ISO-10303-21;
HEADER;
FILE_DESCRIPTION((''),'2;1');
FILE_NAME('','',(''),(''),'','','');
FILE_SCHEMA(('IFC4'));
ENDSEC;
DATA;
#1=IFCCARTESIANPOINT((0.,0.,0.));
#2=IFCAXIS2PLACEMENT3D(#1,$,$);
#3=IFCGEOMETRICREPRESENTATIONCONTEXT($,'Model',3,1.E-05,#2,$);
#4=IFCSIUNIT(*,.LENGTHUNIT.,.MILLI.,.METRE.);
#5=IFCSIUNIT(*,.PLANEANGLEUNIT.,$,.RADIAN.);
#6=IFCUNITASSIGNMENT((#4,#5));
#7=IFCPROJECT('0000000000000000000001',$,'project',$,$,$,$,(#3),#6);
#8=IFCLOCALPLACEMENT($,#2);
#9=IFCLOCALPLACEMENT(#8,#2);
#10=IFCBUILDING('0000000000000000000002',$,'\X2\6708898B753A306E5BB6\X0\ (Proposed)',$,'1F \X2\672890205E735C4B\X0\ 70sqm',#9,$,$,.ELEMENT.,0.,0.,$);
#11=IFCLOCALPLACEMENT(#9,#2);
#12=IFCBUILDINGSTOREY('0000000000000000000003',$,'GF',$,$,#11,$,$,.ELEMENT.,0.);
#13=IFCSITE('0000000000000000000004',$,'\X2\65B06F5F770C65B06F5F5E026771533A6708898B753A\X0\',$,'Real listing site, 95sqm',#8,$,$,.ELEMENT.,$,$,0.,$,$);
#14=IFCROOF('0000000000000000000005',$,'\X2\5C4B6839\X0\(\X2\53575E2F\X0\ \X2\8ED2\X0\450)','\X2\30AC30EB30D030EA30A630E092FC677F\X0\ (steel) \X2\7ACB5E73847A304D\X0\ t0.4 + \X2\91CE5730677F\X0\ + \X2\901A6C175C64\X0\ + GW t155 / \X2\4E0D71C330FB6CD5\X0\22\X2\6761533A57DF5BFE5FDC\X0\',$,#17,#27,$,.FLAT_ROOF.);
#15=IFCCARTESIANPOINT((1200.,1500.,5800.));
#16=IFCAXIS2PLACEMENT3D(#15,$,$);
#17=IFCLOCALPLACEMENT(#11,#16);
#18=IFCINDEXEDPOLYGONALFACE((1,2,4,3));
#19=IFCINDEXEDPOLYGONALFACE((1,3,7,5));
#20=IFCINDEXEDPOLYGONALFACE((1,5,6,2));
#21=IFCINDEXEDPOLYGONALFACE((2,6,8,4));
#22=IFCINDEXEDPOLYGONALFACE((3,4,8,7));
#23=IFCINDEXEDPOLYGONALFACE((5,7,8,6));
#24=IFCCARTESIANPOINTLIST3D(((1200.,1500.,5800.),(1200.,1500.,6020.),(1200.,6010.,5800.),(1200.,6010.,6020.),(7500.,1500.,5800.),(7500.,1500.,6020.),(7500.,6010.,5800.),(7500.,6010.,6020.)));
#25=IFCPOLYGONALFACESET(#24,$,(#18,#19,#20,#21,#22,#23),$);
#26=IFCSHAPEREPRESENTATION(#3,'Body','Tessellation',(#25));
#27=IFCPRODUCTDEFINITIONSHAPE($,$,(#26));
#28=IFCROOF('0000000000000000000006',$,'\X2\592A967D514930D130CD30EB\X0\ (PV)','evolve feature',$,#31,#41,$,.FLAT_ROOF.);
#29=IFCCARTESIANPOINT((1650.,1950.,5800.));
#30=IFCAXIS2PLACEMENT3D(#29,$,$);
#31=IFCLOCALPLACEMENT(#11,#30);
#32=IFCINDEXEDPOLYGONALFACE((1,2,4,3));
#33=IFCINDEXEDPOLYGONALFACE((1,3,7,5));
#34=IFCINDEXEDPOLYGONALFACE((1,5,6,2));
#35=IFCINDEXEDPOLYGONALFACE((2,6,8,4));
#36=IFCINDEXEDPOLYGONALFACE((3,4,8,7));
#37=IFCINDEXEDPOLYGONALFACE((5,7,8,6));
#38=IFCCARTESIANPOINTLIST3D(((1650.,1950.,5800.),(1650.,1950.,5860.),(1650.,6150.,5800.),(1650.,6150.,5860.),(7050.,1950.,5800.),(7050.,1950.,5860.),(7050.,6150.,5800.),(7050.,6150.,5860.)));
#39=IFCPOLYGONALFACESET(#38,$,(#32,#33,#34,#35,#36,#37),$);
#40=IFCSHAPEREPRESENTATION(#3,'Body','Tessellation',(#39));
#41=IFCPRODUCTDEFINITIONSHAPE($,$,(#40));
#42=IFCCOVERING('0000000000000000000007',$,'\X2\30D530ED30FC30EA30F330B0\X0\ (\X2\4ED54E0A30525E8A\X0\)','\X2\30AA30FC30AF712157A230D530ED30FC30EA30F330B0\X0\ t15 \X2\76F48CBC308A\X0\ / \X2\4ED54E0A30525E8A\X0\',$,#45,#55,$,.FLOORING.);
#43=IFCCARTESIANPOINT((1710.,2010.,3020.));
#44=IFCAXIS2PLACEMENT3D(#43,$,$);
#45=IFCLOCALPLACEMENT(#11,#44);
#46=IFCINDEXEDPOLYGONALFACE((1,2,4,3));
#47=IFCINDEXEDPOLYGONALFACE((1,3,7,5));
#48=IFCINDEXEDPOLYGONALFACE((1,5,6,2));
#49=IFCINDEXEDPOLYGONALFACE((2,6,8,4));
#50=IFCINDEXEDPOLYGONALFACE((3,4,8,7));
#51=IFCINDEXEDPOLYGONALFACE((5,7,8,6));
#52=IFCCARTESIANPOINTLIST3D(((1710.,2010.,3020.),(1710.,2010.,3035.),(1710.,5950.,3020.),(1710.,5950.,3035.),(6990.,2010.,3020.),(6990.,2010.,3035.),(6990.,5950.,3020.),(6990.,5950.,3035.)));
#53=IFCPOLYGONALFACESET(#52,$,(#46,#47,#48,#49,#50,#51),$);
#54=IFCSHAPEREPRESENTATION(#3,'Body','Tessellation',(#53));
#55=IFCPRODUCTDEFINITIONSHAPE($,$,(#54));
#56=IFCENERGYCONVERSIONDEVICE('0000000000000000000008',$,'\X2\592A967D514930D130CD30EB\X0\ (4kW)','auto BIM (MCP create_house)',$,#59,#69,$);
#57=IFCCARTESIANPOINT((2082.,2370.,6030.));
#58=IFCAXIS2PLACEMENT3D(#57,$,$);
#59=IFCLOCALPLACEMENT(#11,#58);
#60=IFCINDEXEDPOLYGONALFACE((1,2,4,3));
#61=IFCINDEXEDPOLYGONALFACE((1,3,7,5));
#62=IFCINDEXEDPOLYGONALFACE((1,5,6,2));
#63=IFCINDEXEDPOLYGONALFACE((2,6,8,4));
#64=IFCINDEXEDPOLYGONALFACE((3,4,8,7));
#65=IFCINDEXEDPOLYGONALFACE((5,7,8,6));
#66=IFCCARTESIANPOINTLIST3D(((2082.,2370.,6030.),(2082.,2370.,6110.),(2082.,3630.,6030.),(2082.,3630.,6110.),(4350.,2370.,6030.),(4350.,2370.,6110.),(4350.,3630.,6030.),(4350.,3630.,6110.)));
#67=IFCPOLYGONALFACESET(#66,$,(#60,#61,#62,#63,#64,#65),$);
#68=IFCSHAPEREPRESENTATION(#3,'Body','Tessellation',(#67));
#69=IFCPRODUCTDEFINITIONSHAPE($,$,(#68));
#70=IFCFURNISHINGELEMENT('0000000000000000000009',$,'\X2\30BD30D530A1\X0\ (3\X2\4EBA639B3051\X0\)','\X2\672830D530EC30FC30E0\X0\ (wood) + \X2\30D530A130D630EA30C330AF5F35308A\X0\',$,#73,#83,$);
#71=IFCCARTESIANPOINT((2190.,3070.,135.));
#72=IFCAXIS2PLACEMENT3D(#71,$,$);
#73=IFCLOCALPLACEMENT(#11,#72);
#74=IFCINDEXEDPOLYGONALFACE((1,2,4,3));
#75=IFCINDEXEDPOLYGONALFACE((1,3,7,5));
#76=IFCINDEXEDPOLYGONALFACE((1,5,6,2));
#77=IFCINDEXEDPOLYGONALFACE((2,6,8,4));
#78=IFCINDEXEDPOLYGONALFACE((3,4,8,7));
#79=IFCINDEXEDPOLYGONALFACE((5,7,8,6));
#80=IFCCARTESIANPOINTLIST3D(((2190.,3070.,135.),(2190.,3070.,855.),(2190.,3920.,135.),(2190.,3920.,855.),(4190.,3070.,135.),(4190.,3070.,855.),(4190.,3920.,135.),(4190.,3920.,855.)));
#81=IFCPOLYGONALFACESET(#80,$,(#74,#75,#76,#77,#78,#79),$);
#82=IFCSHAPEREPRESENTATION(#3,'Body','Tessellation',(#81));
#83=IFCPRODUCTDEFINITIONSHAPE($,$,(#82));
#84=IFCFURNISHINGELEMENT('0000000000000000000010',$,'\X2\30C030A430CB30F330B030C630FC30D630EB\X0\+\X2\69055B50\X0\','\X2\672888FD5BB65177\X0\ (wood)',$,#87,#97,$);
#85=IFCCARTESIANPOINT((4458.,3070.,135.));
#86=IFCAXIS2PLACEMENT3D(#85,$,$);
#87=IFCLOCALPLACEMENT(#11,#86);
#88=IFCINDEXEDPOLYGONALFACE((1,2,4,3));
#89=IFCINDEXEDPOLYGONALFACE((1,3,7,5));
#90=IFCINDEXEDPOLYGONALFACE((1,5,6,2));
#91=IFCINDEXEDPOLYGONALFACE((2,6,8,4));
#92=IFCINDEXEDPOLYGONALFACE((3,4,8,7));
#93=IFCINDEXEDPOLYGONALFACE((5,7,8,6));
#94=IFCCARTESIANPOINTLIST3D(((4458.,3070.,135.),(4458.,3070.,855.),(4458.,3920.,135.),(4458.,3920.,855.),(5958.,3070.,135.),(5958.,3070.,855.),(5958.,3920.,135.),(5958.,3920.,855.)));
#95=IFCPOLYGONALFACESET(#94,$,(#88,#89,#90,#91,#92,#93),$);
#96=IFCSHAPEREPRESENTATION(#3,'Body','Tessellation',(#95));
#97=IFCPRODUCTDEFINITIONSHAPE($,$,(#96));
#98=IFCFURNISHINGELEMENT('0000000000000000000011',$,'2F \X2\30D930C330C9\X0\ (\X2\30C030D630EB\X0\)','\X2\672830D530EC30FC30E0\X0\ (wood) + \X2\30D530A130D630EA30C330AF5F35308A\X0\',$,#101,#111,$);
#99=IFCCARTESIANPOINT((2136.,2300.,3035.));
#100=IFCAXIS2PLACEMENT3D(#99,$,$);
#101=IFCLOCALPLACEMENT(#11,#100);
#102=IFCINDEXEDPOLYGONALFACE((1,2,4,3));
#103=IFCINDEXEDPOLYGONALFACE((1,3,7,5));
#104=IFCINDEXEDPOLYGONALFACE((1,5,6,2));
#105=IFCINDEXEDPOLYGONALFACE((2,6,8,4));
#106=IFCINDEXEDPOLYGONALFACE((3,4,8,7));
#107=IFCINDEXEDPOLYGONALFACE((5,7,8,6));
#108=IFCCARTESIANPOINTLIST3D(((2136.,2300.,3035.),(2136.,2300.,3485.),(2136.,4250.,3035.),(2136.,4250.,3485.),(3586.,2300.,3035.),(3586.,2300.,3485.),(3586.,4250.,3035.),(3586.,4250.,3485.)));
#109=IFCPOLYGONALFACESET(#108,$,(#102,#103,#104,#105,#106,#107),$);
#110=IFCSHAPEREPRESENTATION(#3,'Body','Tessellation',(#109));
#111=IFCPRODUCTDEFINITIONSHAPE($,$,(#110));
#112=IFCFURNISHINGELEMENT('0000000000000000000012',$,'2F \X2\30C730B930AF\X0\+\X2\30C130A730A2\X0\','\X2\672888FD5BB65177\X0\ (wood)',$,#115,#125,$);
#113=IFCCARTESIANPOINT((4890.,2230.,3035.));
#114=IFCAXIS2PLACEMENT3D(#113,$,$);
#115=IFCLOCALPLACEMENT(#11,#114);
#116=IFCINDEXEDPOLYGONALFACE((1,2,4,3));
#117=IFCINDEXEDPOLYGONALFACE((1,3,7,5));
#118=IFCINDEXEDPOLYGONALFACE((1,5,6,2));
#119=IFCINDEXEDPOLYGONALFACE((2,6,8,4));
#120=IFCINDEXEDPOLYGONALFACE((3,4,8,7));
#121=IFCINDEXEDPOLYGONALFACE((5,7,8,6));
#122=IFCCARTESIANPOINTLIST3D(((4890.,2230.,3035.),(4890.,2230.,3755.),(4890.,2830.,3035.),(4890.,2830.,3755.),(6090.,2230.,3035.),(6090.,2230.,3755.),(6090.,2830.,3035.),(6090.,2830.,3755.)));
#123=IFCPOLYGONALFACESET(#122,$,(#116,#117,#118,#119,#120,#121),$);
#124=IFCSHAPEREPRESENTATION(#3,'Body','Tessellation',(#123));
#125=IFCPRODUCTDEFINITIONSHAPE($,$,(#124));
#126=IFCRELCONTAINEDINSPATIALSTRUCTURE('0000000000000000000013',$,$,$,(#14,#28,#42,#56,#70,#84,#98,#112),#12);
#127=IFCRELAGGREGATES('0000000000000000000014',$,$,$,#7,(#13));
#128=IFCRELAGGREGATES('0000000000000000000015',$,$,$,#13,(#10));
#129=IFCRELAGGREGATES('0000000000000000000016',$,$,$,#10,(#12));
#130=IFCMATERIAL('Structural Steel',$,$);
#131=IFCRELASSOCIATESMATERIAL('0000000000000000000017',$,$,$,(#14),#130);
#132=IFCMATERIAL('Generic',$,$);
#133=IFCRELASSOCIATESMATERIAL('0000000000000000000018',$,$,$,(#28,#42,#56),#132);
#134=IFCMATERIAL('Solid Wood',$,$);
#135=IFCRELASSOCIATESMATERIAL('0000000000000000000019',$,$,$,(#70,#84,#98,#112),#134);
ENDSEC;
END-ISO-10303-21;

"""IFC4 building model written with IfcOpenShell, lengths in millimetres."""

from ifc_helpers import new_model, si_unit, frame, frame_2d, origin, place, context, project, spatial, rectangle, extrude, material, element, save


model = new_model("IFC4")

# Units and contexts
model_context = context("Model", 3, precision=1e-05, world=origin())
ifc_project = project(units=[si_unit("LENGTHUNIT", "METRE", prefix="MILLI"), si_unit("PLANEANGLEUNIT", "RADIAN")], contexts=[model_context])

# Site, building, storey
site_placement = place(None, origin())
site = spatial("IfcSite", under=ifc_project, at=site_placement, Name="新潟県新潟市東区月見町", ObjectType="Real listing site, 95sqm", CompositionType="ELEMENT", RefElevation=0.0)
building_placement = place(site_placement, origin())
building = spatial("IfcBuilding", under=site, at=building_placement, Name="月見町の家 (Proposed)", ObjectType="1F 木造平屋 70sqm", CompositionType="ELEMENT", ElevationOfRefHeight=0.0, ElevationOfTerrain=0.0)
storey_placement = place(building_placement, origin())
storey = spatial("IfcBuildingStorey", under=building, at=storey_placement, Name="GF", CompositionType="ELEMENT", Elevation=0.0)

# Shared definitions
ifc_material_1 = material(Name="Solid Wood")

# Shared definitions
ifc_material_2 = material(Name="Generic")

# Roofs
ifc_material_3 = material(Name="Structural Steel")
for number, where, name in (
    (1, (1200.0, 1500.0, 5800.0), "屋根(南帯 軒450)"),
):
    element("IfcRoof", number, at=place(storey_placement, frame(where)), inside=storey, material=ifc_material_3, Name=name, Description="ガルバリウム鋼板 (steel) 立平葺き t0.4 + 野地板 + 通気層 + GW t155 / 不燃・法22条区域対応", PredefinedType="FLAT_ROOF", context=model_context, shape_type="SweptSolid", body=[
        extrude(rectangle(XDim=6300.0, YDim=4510.0, at=frame_2d((3150.0, 2255.0))), frame((1200.0, 1500.0, 5800.0)), (0.0, 0.0, 1.0), 220.0),
    ])
roof_placement = place(storey_placement, frame((1650.0, 1950.0, 5800.0)))
element("IfcRoof", 2, at=roof_placement, inside=storey, material=ifc_material_2, Name="太陽光パネル (PV)", Description="evolve feature", PredefinedType="FLAT_ROOF", context=model_context, shape_type="SweptSolid", body=[
    extrude(rectangle(XDim=5400.0, YDim=4200.0, at=frame_2d((2700.0, 2100.0))), frame((1650.0, 1950.0, 5800.0)), (0.0, 0.0, 1.0), 60.0),
])

# Covering
covering_placement = place(storey_placement, frame((1710.0, 2010.0, 3020.0)))
element("IfcCovering", 3, at=covering_placement, inside=storey, material=ifc_material_2, Name="フローリング (仕上げ床)", Description="オーク無垢フローリング t15 直貼り / 仕上げ床", PredefinedType="FLOORING", context=model_context, shape_type="SweptSolid", body=[
    extrude(rectangle(XDim=5280.0, YDim=3940.0, at=frame_2d((2640.0, 1970.0))), frame((1710.0, 2010.0, 3020.0)), (0.0, 0.0, 1.0), 15.0),
])

# Energy conversion device
energy_conversion_device_placement = place(storey_placement, frame((2082.0, 2370.0, 6030.0)))
element("IfcEnergyConversionDevice", 4, at=energy_conversion_device_placement, inside=storey, material=ifc_material_2, Name="太陽光パネル (4kW)", Description="auto BIM (MCP create_house)", context=model_context, shape_type="SweptSolid", body=[
    extrude(rectangle(XDim=2268.0, YDim=1260.0, at=frame_2d((1134.0, 630.0))), frame((2082.0, 2370.0, 6030.0)), (0.0, 0.0, 1.0), 80.0),
])

# Furnishing elements
furnishing_1_placement = place(storey_placement, frame((2190.0, 3070.0, 135.0)))
element("IfcFurnishingElement", 5, at=furnishing_1_placement, inside=storey, material=ifc_material_1, Name="ソファ (3人掛け)", Description="木フレーム (wood) + ファブリック張り", context=model_context, shape_type="SweptSolid", body=[
    extrude(rectangle(XDim=2000.0, YDim=850.0, at=frame_2d((1000.0, 425.0))), frame((2190.0, 3070.0, 135.0)), (0.0, 0.0, 1.0), 720.0),
])
furnishing_2_placement = place(storey_placement, frame((4458.0, 3070.0, 135.0)))
element("IfcFurnishingElement", 6, at=furnishing_2_placement, inside=storey, material=ifc_material_1, Name="ダイニングテーブル+椅子", Description="木製家具 (wood)", context=model_context, shape_type="SweptSolid", body=[
    extrude(rectangle(XDim=1500.0, YDim=850.0, at=frame_2d((750.0, 425.0))), frame((4458.0, 3070.0, 135.0)), (0.0, 0.0, 1.0), 720.0),
])
furnishing_3_placement = place(storey_placement, frame((2136.0, 2300.0, 3035.0)))
element("IfcFurnishingElement", 7, at=furnishing_3_placement, inside=storey, material=ifc_material_1, Name="2F ベッド (ダブル)", Description="木フレーム (wood) + ファブリック張り", context=model_context, shape_type="SweptSolid", body=[
    extrude(rectangle(XDim=1450.0, YDim=1950.0, at=frame_2d((725.0, 975.0))), frame((2136.0, 2300.0, 3035.0)), (0.0, 0.0, 1.0), 450.0),
])
furnishing_4_placement = place(storey_placement, frame((4890.0, 2230.0, 3035.0)))
element("IfcFurnishingElement", 8, at=furnishing_4_placement, inside=storey, material=ifc_material_1, Name="2F デスク+チェア", Description="木製家具 (wood)", context=model_context, shape_type="SweptSolid", body=[
    extrude(rectangle(XDim=1200.0, YDim=600.0, at=frame_2d((600.0, 300.0))), frame((4890.0, 2230.0, 3035.0)), (0.0, 0.0, 1.0), 720.0),
])

save(model, "model.ifc")
